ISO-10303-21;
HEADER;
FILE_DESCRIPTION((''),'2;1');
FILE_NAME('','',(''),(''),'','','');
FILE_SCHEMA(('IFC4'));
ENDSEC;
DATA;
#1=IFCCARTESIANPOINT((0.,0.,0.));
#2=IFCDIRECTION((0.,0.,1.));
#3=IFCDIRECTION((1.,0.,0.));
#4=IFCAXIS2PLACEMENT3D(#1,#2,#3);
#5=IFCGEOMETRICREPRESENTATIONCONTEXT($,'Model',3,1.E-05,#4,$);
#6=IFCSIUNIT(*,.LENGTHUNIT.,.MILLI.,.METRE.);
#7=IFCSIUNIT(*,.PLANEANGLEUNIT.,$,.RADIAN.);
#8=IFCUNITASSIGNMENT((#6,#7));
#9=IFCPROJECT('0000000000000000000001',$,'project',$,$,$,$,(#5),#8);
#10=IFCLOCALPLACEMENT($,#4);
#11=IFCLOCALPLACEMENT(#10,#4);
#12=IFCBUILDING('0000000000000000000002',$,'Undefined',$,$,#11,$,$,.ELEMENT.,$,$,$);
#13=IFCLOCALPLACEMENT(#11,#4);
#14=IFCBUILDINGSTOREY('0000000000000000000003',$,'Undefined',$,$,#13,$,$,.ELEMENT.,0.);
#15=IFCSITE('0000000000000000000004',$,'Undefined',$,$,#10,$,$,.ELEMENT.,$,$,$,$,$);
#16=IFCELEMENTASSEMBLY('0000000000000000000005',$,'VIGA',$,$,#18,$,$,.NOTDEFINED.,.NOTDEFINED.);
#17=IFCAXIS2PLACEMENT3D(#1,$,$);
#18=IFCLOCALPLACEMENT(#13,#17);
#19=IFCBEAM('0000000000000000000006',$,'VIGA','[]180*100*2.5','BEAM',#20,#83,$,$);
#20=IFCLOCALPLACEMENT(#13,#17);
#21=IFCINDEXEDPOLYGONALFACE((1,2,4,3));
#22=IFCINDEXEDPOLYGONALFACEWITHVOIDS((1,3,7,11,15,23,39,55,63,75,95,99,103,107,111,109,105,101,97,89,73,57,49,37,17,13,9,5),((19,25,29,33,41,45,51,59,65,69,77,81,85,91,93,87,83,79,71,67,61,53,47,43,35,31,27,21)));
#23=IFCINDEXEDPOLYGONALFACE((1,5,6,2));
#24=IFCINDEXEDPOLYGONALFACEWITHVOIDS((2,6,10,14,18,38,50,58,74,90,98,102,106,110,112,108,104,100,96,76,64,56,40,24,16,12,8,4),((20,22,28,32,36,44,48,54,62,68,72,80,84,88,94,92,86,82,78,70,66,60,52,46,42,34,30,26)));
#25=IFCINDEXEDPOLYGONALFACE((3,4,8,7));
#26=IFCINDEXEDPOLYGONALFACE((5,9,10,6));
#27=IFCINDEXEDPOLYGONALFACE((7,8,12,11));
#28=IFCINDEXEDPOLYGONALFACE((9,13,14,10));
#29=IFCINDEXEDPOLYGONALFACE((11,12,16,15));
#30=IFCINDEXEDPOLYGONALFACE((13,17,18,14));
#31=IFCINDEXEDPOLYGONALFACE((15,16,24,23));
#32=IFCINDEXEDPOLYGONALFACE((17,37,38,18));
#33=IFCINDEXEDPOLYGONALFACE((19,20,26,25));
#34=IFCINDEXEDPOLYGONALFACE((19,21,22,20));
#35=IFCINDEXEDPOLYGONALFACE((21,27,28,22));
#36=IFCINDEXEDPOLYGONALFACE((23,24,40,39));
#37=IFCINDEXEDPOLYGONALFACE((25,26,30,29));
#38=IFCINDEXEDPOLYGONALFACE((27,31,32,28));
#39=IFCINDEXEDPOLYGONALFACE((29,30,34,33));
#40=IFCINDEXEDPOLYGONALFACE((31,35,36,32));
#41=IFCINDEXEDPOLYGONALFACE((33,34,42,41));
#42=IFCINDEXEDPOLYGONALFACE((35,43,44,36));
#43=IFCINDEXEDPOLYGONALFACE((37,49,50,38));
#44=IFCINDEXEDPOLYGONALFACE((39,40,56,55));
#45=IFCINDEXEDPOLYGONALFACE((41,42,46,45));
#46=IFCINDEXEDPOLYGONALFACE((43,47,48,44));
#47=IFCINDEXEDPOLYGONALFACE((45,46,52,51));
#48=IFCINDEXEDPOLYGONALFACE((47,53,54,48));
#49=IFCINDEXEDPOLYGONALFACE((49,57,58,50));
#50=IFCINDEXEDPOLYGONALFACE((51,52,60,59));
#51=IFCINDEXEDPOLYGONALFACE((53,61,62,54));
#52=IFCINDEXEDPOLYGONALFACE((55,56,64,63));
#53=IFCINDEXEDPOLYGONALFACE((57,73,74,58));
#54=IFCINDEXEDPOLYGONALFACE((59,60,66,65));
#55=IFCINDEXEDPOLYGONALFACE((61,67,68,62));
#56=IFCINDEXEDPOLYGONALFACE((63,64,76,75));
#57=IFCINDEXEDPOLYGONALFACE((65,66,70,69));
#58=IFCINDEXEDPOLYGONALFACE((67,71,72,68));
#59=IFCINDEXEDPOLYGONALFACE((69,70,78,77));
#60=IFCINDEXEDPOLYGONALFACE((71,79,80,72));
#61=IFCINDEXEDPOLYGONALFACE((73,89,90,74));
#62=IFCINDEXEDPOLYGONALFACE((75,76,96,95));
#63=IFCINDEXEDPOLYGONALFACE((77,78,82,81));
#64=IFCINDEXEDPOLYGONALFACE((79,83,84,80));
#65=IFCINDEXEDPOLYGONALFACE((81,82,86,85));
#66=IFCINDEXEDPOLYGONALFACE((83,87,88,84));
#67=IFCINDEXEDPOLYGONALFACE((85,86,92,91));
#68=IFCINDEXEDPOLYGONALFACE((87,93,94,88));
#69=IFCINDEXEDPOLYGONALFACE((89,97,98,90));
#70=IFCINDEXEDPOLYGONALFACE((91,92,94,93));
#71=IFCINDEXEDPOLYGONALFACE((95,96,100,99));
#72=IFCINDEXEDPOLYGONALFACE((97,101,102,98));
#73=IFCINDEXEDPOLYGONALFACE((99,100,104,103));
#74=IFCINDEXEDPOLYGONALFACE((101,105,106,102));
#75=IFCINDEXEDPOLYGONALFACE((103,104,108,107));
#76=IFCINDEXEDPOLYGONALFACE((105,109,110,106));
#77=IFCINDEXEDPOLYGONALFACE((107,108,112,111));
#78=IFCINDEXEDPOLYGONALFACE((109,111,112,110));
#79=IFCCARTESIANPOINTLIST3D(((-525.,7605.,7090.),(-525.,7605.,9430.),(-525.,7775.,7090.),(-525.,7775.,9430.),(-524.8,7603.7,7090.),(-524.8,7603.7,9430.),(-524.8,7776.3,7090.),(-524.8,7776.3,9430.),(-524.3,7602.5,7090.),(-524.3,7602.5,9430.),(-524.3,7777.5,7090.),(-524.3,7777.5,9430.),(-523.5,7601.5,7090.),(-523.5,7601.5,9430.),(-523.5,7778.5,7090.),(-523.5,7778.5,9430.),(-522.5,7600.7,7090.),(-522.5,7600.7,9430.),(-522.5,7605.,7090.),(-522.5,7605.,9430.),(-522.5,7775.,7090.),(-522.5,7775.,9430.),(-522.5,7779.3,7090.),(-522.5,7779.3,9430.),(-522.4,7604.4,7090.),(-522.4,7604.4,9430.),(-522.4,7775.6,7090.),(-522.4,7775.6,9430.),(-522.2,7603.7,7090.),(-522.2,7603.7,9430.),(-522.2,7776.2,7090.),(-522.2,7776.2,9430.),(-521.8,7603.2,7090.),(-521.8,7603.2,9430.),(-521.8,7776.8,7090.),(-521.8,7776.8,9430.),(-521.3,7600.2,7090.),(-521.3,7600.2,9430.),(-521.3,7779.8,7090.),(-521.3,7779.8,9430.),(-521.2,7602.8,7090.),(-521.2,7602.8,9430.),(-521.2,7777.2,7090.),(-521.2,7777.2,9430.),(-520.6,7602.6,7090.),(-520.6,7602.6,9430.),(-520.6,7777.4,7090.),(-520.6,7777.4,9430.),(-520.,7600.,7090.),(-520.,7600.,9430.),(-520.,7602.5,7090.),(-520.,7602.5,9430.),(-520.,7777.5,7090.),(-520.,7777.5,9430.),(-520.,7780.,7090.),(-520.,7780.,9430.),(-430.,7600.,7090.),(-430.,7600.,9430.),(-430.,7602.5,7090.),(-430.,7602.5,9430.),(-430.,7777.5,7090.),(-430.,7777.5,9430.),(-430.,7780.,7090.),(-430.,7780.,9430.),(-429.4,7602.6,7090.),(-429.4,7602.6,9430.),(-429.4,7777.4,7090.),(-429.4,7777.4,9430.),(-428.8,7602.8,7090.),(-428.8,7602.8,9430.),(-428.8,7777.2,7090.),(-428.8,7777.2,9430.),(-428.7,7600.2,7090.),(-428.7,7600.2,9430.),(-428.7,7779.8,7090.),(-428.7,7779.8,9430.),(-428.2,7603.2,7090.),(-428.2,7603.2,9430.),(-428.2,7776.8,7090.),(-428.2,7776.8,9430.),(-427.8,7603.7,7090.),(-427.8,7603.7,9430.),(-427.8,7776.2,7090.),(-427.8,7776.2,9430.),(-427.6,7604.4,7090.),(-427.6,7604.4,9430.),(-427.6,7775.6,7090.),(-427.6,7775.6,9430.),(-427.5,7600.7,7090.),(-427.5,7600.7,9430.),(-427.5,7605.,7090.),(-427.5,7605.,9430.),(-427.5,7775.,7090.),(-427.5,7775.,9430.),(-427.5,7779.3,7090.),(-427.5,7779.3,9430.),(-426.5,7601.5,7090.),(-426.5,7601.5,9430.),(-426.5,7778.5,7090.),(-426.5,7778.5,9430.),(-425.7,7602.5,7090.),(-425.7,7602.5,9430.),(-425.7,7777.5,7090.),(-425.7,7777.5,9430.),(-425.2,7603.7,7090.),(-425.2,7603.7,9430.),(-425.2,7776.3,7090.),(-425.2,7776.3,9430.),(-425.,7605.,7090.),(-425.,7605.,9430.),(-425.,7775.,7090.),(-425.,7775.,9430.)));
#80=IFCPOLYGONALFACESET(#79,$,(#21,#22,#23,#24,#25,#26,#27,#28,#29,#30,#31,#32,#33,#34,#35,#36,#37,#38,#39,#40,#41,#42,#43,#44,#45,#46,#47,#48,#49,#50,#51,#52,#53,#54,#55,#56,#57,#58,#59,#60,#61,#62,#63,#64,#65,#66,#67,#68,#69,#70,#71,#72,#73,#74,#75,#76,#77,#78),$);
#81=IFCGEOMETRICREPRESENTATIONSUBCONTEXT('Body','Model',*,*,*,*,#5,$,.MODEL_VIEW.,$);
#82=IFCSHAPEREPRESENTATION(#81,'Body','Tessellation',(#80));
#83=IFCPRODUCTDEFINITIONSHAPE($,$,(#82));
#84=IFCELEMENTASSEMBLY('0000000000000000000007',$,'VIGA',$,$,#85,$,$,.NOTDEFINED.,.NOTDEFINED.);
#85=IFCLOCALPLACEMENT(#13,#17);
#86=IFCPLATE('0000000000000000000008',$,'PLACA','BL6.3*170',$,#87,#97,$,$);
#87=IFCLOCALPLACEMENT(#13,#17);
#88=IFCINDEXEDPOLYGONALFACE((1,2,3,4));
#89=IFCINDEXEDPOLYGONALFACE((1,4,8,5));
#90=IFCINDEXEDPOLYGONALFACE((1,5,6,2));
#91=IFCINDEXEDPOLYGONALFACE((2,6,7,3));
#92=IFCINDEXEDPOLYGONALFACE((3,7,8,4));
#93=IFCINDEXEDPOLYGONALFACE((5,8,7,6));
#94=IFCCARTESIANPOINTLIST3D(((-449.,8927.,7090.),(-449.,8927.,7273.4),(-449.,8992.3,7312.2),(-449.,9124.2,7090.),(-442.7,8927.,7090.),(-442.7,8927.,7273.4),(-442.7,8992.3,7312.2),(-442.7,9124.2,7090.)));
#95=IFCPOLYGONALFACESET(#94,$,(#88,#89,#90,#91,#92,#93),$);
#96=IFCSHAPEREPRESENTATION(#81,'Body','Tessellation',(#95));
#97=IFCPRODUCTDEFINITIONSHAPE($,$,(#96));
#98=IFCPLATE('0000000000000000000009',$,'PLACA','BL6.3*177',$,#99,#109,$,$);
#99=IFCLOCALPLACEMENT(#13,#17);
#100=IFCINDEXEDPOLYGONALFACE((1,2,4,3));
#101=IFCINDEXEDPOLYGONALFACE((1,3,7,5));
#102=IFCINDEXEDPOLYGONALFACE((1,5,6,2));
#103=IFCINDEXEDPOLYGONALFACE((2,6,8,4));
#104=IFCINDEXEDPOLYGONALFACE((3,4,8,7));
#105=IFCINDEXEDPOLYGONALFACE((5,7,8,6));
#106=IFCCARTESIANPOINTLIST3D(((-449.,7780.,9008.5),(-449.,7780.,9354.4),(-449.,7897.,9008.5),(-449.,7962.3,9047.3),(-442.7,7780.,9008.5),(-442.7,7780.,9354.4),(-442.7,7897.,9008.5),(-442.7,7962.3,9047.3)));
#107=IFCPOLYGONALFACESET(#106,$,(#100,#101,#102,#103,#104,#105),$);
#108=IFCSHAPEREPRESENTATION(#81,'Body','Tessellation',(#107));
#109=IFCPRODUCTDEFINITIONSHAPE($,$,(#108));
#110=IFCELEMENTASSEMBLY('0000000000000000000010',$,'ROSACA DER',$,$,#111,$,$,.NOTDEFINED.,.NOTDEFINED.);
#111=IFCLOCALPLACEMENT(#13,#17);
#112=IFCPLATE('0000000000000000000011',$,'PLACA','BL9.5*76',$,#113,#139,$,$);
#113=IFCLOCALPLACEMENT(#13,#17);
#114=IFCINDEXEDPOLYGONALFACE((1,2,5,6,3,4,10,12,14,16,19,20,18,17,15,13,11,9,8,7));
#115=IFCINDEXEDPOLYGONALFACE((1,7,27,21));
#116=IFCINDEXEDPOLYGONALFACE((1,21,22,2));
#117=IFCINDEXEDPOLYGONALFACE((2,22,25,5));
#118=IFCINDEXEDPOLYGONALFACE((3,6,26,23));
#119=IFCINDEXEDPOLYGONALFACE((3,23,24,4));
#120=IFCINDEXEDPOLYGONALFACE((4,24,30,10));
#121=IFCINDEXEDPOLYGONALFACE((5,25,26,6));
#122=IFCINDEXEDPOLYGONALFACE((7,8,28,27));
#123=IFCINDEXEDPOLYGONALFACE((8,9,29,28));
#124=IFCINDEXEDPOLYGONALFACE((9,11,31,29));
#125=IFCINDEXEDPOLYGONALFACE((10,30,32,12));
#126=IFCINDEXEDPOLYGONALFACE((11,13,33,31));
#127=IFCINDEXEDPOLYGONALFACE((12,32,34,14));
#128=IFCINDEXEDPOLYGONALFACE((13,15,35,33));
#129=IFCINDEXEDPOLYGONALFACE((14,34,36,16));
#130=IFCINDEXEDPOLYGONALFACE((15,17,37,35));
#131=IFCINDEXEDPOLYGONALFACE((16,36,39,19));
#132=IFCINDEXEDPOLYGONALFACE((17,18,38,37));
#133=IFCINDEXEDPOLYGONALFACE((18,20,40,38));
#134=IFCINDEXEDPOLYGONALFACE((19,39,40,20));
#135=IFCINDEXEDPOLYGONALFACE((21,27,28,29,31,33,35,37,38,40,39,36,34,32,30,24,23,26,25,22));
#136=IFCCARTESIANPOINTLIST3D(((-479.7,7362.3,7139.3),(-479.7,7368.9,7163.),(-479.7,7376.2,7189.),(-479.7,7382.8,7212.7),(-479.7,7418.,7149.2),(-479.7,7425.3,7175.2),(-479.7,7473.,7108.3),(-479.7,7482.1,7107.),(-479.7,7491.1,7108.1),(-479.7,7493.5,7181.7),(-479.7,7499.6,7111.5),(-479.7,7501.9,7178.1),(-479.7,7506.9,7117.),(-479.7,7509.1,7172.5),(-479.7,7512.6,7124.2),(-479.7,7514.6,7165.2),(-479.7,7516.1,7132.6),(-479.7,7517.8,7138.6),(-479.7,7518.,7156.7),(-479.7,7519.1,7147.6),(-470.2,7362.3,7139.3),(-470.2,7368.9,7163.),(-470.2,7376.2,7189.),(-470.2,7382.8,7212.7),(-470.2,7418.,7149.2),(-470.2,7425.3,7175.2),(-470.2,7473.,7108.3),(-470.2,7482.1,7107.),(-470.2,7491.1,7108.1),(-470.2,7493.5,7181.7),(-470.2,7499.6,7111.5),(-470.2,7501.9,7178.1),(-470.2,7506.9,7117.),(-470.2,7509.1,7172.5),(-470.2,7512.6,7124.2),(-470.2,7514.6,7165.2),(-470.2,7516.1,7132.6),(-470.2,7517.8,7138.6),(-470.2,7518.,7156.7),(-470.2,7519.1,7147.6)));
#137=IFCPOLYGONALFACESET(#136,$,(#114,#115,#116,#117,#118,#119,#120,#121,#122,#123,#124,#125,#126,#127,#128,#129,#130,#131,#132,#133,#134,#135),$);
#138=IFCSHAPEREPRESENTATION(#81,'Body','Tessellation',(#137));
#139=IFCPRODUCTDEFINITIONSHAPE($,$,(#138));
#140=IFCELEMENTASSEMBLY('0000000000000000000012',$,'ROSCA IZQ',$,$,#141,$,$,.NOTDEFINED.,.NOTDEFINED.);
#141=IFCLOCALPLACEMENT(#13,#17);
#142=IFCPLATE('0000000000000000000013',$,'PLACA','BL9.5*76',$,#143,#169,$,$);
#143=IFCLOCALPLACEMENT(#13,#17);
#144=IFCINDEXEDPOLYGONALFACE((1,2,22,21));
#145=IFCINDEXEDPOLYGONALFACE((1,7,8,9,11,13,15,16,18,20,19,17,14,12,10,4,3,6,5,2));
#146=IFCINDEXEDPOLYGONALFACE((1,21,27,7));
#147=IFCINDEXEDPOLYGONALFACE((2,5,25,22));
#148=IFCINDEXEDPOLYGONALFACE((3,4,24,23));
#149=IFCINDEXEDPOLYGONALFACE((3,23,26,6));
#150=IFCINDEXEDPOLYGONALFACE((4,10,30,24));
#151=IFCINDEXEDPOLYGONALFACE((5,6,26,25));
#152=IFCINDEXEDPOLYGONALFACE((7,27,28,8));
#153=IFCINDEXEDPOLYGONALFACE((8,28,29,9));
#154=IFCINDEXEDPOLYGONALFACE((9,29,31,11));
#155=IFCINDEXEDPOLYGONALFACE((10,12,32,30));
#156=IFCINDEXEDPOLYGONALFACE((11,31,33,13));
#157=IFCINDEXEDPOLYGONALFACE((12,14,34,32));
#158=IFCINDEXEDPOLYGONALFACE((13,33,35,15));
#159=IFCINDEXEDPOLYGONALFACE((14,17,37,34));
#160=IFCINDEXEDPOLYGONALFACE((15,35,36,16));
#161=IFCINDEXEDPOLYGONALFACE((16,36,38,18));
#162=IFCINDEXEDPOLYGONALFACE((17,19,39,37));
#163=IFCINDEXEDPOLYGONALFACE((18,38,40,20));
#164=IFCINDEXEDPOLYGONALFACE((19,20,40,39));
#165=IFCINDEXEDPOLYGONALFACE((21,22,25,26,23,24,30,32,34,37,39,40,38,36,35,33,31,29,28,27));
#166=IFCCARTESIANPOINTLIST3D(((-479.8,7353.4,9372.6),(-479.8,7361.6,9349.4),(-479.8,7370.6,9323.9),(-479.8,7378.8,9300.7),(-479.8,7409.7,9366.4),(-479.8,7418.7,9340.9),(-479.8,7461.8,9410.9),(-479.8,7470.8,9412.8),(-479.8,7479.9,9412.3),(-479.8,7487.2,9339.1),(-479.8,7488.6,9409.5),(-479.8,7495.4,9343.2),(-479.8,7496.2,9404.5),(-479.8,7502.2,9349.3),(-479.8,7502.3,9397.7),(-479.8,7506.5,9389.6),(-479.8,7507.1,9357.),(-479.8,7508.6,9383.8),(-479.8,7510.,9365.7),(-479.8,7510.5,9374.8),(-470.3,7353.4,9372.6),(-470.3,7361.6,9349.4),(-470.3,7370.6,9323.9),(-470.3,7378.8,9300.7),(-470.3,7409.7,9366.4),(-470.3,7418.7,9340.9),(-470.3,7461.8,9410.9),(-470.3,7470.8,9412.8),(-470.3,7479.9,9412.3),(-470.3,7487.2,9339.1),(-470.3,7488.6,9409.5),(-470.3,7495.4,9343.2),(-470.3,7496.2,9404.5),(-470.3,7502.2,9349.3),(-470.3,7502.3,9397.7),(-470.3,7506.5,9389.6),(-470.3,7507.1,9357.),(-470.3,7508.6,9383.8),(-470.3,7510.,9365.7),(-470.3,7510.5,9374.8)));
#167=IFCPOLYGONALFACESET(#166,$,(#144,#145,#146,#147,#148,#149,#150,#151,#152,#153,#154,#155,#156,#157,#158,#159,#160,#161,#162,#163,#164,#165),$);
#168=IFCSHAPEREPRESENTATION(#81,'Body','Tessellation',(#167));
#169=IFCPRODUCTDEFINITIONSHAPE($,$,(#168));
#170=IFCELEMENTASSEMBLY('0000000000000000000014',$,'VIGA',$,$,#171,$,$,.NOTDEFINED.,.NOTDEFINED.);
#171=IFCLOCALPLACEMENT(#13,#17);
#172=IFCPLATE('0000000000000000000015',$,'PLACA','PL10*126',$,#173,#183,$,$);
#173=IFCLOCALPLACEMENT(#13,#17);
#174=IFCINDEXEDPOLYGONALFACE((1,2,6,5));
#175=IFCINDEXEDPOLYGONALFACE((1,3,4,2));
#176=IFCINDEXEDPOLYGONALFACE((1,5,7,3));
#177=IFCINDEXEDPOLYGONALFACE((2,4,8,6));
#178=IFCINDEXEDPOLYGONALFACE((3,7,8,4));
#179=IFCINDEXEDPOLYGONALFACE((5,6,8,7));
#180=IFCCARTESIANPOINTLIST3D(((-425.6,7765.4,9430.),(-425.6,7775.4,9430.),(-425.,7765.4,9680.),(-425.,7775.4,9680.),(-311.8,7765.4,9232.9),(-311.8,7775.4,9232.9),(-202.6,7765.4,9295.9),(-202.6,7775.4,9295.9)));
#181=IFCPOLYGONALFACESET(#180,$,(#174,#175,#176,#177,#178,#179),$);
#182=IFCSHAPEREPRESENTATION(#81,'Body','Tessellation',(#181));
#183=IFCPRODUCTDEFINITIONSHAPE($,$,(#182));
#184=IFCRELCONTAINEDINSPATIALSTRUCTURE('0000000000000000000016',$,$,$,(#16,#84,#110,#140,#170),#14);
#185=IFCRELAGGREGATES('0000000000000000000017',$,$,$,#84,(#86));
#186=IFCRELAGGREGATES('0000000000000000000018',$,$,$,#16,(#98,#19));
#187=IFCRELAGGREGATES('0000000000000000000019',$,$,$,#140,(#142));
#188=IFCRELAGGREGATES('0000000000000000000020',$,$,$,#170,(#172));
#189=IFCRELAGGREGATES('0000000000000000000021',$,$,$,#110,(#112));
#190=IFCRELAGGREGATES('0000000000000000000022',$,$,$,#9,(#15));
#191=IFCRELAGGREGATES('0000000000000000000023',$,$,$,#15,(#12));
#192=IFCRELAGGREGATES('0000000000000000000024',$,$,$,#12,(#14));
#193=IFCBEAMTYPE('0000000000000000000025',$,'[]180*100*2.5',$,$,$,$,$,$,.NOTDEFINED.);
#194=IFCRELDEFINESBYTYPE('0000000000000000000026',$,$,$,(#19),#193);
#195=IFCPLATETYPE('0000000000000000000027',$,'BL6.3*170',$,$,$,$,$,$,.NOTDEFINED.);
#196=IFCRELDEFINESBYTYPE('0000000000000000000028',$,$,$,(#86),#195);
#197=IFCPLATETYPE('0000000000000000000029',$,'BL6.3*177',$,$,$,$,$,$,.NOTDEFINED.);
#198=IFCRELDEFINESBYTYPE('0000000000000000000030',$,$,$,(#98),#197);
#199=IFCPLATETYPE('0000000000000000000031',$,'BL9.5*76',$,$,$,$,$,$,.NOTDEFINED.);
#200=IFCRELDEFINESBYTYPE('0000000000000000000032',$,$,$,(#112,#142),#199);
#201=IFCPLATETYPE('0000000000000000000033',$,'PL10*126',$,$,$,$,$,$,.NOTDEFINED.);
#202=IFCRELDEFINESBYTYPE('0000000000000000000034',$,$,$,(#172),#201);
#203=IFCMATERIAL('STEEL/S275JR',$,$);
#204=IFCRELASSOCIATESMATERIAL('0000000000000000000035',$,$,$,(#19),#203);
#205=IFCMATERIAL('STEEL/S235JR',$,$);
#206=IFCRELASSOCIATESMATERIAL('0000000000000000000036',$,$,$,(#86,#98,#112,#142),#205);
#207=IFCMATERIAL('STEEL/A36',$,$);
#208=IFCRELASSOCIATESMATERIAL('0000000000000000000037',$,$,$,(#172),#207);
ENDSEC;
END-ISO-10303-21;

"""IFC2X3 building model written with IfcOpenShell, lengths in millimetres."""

from ifc_helpers import new_model, si_unit, frame, frame_2d, origin_with_axes, origin_2d_with_axis, place, context, subcontext, project, spatial, polyline, circle_curve, parameter, trimmed, segment, composite_curve, rectangle, hollow_rectangle, outline, extrude, boolean, material, type_object, element, aggregate, save


model = new_model("IFC2X3")

# Units and contexts
model_context = context("Model", 3, precision=1e-05, world=origin_with_axes())
body_context = subcontext(model_context, "Body", "Model", "MODEL_VIEW")
ifc_project = project(units=[si_unit("LENGTHUNIT", "METRE", prefix="MILLI"), si_unit("PLANEANGLEUNIT", "RADIAN")], contexts=[model_context])

# Site, building, storey
site_placement = place(None, origin_with_axes())
site = spatial("IfcSite", under=ifc_project, at=site_placement, Name="Undefined", CompositionType="ELEMENT")
building_placement = place(site_placement, origin_with_axes())
building = spatial("IfcBuilding", under=site, at=building_placement, Name="Undefined", CompositionType="ELEMENT")
storey_placement = place(building_placement, origin_with_axes())
storey = spatial("IfcBuildingStorey", under=building, at=storey_placement, Name="Undefined", CompositionType="ELEMENT", Elevation=0.0)

# Element assembly, beam
ifc_material_1 = material(Name="STEEL/S275JR")
assembly_1_placement = place(storey_placement, origin_with_axes())
assembly_1 = element("IfcElementAssembly", 1, at=assembly_1_placement, inside=storey, Name="VIGA", AssemblyPlace="NOTDEFINED", PredefinedType="NOTDEFINED")
beam_type_1 = type_object("IfcBeamType", Name="[]180*100*2.5", PredefinedType="NOTDEFINED")
beam_1_placement = place(assembly_1_placement, frame((-475.0, 7690.0, 7090.0), z_axis=(0.0, 1.0, 0.0), x_axis=(0.0, 0.0, 1.0)))
beam_1 = element("IfcBeam", 2, at=beam_1_placement, type_object=beam_type_1, material=ifc_material_1, Name="VIGA", Description="[]180*100*2.5", ObjectType="BEAM", context=body_context, shape_type="SweptSolid", body=[
    extrude(hollow_rectangle(XDim=100.0, YDim=180.0, WallThickness=2.5, InnerFilletRadius=2.5, OuterFilletRadius=5.0, at=origin_2d_with_axis()), frame((2340.0, 0.0, 0.0), z_axis=(-1.0, 0.0, 0.0), x_axis=(0.0, -1.0, 0.0)), (0.0, 0.0, 1.0), 2340.0),
])

# Element assembly, plate
assembly_2_placement = place(storey_placement, origin_with_axes())
assembly_2 = element("IfcElementAssembly", 3, at=assembly_2_placement, inside=storey, Name="VIGA", AssemblyPlace="NOTDEFINED", PredefinedType="NOTDEFINED")
ifc_material_2 = material(Name="STEEL/S235JR")
plate_type_1 = type_object("IfcPlateType", Name="BL6.3*170", PredefinedType="NOTDEFINED")
plate_1_placement = place(assembly_2_placement, frame((-445.9, 8927.0, 7090.0), z_axis=(1.0, 0.0, 0.0), x_axis=(0.0, 1.0, 0.0)))
plate_1 = element("IfcPlate", 4, at=plate_1_placement, type_object=plate_type_1, material=ifc_material_2, Name="PLACA", Description="BL6.3*170", context=body_context, shape_type="SweptSolid", body=[
    extrude(outline(polyline([(0.0, 0.0), (197.2, 0.0), (65.4, 222.2), (0.0, 183.4), (0.0, 0.0)])), frame((0.0, 0.0, -3.1), z_axis=(0.0, 0.0, 1.0), x_axis=(1.0, 0.0, 0.0)), (0.0, 0.0, 1.0), 6.3),
])
aggregate(assembly_2, [plate_1])

# Plate
plate_type_2 = type_object("IfcPlateType", Name="BL6.3*177", PredefinedType="NOTDEFINED")
plate_2_placement = place(assembly_1_placement, frame((-445.9, 7780.0, 9354.4), z_axis=(1.0, 0.0, 0.0), x_axis=(0.0, 0.0, -1.0)))
plate_2 = element("IfcPlate", 5, at=plate_2_placement, type_object=plate_type_2, material=ifc_material_2, Name="PLACA", Description="BL6.3*177", context=body_context, shape_type="SweptSolid", body=[
    extrude(outline(polyline([(0.0, 0.0), (346.0, 0.0), (346.0, 117.0), (307.2, 182.3), (0.0, 0.0)])), frame((0.0, 0.0, -3.1), z_axis=(0.0, 0.0, 1.0), x_axis=(1.0, 0.0, 0.0)), (0.0, 0.0, 1.0), 6.3),
])
aggregate(assembly_1, [plate_2, beam_1])

# Element assemblies, plates
assembly_3_placement = place(storey_placement, origin_with_axes())
assembly_3 = element("IfcElementAssembly", 6, at=assembly_3_placement, inside=storey, Name="ROSACA DER", AssemblyPlace="NOTDEFINED", PredefinedType="NOTDEFINED")
plate_type_3 = type_object("IfcPlateType", Name="BL9.5*76", PredefinedType="NOTDEFINED")
plate_3_placement = place(assembly_3_placement, frame((-475.0, 7527.2, 7172.3), z_axis=(-1.0, 0.0, 0.0), x_axis=(0.0, -0.269246, -0.963072)))
plate_3 = element("IfcPlate", 7, at=plate_3_placement, type_object=plate_type_3, material=ifc_material_2, Name="PLACA", Description="BL9.5*76", context=body_context, shape_type="CSG", body=[
    boolean("DIFFERENCE", extrude(outline(composite_curve([segment(trimmed(circle_curve(frame_2d((35.0, 35.0), x_axis=(-1.0, 0.0)), 35.0), [parameter(0.0)], [parameter(1.570796)], True, "PARAMETER"), True, "CONTINUOUS"), segment(polyline([(35.0, 0.0), (41.2, 0.0)]), True, "CONTINUOUS"), segment(trimmed(circle_curve(frame_2d((41.2, 35.0), x_axis=(0.0, -1.0)), 35.0), [parameter(0.0)], [parameter(1.570796)], True, "PARAMETER"), True, "CONTINUOUS"), segment(polyline([(76.2, 35.0), (76.2, 150.0), (0.0, 150.0), (0.0, 35.0)]), True, "CONTINUOUS")], self_intersect=True)), frame((0.0, 0.0, -4.7), z_axis=(0.0, 0.0, 1.0), x_axis=(1.0, 0.0, 0.0)), (0.0, 0.0, 1.0), 9.5), extrude(rectangle(XDim=27.0, YDim=27.0, at=origin_2d_with_axis()), frame((38.1, 250.0, 0.0), z_axis=(0.0, -1.0, 0.0), x_axis=(0.0, 0.0, 1.0)), (0.0, 0.0, 1.0), 151.0)),
])
assembly_4_placement = place(storey_placement, origin_with_axes())
assembly_4 = element("IfcElementAssembly", 8, at=assembly_4_placement, inside=storey, Name="ROSCA IZQ", AssemblyPlace="NOTDEFINED", PredefinedType="NOTDEFINED")
plate_4_placement = place(assembly_4_placement, frame((-475.0, 7520.2, 9350.8), z_axis=(1.0, 0.0, 0.0), x_axis=(0.0, -0.333508, 0.942747)))
plate_4 = element("IfcPlate", 9, at=plate_4_placement, type_object=plate_type_3, material=ifc_material_2, Name="PLACA", Description="BL9.5*76", context=body_context, shape_type="CSG", body=[
    boolean("DIFFERENCE", extrude(outline(composite_curve([segment(trimmed(circle_curve(frame_2d((35.0, 35.0), x_axis=(-1.0, 0.0)), 35.0), [parameter(0.0)], [parameter(1.570796)], True, "PARAMETER"), True, "CONTINUOUS"), segment(polyline([(35.0, 0.0), (41.2, 0.0)]), True, "CONTINUOUS"), segment(trimmed(circle_curve(frame_2d((41.2, 35.0), x_axis=(0.0, -1.0)), 35.0), [parameter(0.0)], [parameter(1.570796)], True, "PARAMETER"), True, "CONTINUOUS"), segment(polyline([(76.2, 35.0), (76.2, 150.0), (0.0, 150.0), (0.0, 35.0)]), True, "CONTINUOUS")], self_intersect=True)), frame((0.0, 0.0, -4.7), z_axis=(0.0, 0.0, 1.0), x_axis=(1.0, 0.0, 0.0)), (0.0, 0.0, 1.0), 9.5), extrude(rectangle(XDim=27.0, YDim=27.0, at=origin_2d_with_axis()), frame((38.1, 250.0, 0.0), z_axis=(0.0, -1.0, 0.0), x_axis=(0.0, 0.0, 1.0)), (0.0, 0.0, 1.0), 151.0)),
])
aggregate(assembly_4, [plate_4])
assembly_5_placement = place(storey_placement, origin_with_axes())
assembly_5 = element("IfcElementAssembly", 10, at=assembly_5_placement, inside=storey, Name="VIGA", AssemblyPlace="NOTDEFINED", PredefinedType="NOTDEFINED")
ifc_material_3 = material(Name="STEEL/A36")
plate_type_4 = type_object("IfcPlateType", Name="PL10*126", PredefinedType="NOTDEFINED")
plate_5_placement = place(assembly_5_placement, frame((-425.0, 7770.4, 9680.0), z_axis=(0.0, 1.0, 0.0), x_axis=(0.500975, 0.0, -0.865462)))
plate_5 = element("IfcPlate", 11, at=plate_5_placement, type_object=plate_type_4, material=ifc_material_3, Name="PLACA", Description="PL10*126", context=body_context, shape_type="SweptSolid", body=[
    extrude(outline(polyline([(0.0, 0.0), (443.9, 0.0), (443.7, 126.0), (216.1, 125.7), (0.0, 0.0)])), frame((0.0, 0.0, -5.0), z_axis=(0.0, 0.0, 1.0), x_axis=(1.0, 0.0, 0.0)), (0.0, 0.0, 1.0), 10.0),
])

aggregate(assembly_5, [plate_5])

aggregate(assembly_3, [plate_3])

save(model, "model.ifc")
